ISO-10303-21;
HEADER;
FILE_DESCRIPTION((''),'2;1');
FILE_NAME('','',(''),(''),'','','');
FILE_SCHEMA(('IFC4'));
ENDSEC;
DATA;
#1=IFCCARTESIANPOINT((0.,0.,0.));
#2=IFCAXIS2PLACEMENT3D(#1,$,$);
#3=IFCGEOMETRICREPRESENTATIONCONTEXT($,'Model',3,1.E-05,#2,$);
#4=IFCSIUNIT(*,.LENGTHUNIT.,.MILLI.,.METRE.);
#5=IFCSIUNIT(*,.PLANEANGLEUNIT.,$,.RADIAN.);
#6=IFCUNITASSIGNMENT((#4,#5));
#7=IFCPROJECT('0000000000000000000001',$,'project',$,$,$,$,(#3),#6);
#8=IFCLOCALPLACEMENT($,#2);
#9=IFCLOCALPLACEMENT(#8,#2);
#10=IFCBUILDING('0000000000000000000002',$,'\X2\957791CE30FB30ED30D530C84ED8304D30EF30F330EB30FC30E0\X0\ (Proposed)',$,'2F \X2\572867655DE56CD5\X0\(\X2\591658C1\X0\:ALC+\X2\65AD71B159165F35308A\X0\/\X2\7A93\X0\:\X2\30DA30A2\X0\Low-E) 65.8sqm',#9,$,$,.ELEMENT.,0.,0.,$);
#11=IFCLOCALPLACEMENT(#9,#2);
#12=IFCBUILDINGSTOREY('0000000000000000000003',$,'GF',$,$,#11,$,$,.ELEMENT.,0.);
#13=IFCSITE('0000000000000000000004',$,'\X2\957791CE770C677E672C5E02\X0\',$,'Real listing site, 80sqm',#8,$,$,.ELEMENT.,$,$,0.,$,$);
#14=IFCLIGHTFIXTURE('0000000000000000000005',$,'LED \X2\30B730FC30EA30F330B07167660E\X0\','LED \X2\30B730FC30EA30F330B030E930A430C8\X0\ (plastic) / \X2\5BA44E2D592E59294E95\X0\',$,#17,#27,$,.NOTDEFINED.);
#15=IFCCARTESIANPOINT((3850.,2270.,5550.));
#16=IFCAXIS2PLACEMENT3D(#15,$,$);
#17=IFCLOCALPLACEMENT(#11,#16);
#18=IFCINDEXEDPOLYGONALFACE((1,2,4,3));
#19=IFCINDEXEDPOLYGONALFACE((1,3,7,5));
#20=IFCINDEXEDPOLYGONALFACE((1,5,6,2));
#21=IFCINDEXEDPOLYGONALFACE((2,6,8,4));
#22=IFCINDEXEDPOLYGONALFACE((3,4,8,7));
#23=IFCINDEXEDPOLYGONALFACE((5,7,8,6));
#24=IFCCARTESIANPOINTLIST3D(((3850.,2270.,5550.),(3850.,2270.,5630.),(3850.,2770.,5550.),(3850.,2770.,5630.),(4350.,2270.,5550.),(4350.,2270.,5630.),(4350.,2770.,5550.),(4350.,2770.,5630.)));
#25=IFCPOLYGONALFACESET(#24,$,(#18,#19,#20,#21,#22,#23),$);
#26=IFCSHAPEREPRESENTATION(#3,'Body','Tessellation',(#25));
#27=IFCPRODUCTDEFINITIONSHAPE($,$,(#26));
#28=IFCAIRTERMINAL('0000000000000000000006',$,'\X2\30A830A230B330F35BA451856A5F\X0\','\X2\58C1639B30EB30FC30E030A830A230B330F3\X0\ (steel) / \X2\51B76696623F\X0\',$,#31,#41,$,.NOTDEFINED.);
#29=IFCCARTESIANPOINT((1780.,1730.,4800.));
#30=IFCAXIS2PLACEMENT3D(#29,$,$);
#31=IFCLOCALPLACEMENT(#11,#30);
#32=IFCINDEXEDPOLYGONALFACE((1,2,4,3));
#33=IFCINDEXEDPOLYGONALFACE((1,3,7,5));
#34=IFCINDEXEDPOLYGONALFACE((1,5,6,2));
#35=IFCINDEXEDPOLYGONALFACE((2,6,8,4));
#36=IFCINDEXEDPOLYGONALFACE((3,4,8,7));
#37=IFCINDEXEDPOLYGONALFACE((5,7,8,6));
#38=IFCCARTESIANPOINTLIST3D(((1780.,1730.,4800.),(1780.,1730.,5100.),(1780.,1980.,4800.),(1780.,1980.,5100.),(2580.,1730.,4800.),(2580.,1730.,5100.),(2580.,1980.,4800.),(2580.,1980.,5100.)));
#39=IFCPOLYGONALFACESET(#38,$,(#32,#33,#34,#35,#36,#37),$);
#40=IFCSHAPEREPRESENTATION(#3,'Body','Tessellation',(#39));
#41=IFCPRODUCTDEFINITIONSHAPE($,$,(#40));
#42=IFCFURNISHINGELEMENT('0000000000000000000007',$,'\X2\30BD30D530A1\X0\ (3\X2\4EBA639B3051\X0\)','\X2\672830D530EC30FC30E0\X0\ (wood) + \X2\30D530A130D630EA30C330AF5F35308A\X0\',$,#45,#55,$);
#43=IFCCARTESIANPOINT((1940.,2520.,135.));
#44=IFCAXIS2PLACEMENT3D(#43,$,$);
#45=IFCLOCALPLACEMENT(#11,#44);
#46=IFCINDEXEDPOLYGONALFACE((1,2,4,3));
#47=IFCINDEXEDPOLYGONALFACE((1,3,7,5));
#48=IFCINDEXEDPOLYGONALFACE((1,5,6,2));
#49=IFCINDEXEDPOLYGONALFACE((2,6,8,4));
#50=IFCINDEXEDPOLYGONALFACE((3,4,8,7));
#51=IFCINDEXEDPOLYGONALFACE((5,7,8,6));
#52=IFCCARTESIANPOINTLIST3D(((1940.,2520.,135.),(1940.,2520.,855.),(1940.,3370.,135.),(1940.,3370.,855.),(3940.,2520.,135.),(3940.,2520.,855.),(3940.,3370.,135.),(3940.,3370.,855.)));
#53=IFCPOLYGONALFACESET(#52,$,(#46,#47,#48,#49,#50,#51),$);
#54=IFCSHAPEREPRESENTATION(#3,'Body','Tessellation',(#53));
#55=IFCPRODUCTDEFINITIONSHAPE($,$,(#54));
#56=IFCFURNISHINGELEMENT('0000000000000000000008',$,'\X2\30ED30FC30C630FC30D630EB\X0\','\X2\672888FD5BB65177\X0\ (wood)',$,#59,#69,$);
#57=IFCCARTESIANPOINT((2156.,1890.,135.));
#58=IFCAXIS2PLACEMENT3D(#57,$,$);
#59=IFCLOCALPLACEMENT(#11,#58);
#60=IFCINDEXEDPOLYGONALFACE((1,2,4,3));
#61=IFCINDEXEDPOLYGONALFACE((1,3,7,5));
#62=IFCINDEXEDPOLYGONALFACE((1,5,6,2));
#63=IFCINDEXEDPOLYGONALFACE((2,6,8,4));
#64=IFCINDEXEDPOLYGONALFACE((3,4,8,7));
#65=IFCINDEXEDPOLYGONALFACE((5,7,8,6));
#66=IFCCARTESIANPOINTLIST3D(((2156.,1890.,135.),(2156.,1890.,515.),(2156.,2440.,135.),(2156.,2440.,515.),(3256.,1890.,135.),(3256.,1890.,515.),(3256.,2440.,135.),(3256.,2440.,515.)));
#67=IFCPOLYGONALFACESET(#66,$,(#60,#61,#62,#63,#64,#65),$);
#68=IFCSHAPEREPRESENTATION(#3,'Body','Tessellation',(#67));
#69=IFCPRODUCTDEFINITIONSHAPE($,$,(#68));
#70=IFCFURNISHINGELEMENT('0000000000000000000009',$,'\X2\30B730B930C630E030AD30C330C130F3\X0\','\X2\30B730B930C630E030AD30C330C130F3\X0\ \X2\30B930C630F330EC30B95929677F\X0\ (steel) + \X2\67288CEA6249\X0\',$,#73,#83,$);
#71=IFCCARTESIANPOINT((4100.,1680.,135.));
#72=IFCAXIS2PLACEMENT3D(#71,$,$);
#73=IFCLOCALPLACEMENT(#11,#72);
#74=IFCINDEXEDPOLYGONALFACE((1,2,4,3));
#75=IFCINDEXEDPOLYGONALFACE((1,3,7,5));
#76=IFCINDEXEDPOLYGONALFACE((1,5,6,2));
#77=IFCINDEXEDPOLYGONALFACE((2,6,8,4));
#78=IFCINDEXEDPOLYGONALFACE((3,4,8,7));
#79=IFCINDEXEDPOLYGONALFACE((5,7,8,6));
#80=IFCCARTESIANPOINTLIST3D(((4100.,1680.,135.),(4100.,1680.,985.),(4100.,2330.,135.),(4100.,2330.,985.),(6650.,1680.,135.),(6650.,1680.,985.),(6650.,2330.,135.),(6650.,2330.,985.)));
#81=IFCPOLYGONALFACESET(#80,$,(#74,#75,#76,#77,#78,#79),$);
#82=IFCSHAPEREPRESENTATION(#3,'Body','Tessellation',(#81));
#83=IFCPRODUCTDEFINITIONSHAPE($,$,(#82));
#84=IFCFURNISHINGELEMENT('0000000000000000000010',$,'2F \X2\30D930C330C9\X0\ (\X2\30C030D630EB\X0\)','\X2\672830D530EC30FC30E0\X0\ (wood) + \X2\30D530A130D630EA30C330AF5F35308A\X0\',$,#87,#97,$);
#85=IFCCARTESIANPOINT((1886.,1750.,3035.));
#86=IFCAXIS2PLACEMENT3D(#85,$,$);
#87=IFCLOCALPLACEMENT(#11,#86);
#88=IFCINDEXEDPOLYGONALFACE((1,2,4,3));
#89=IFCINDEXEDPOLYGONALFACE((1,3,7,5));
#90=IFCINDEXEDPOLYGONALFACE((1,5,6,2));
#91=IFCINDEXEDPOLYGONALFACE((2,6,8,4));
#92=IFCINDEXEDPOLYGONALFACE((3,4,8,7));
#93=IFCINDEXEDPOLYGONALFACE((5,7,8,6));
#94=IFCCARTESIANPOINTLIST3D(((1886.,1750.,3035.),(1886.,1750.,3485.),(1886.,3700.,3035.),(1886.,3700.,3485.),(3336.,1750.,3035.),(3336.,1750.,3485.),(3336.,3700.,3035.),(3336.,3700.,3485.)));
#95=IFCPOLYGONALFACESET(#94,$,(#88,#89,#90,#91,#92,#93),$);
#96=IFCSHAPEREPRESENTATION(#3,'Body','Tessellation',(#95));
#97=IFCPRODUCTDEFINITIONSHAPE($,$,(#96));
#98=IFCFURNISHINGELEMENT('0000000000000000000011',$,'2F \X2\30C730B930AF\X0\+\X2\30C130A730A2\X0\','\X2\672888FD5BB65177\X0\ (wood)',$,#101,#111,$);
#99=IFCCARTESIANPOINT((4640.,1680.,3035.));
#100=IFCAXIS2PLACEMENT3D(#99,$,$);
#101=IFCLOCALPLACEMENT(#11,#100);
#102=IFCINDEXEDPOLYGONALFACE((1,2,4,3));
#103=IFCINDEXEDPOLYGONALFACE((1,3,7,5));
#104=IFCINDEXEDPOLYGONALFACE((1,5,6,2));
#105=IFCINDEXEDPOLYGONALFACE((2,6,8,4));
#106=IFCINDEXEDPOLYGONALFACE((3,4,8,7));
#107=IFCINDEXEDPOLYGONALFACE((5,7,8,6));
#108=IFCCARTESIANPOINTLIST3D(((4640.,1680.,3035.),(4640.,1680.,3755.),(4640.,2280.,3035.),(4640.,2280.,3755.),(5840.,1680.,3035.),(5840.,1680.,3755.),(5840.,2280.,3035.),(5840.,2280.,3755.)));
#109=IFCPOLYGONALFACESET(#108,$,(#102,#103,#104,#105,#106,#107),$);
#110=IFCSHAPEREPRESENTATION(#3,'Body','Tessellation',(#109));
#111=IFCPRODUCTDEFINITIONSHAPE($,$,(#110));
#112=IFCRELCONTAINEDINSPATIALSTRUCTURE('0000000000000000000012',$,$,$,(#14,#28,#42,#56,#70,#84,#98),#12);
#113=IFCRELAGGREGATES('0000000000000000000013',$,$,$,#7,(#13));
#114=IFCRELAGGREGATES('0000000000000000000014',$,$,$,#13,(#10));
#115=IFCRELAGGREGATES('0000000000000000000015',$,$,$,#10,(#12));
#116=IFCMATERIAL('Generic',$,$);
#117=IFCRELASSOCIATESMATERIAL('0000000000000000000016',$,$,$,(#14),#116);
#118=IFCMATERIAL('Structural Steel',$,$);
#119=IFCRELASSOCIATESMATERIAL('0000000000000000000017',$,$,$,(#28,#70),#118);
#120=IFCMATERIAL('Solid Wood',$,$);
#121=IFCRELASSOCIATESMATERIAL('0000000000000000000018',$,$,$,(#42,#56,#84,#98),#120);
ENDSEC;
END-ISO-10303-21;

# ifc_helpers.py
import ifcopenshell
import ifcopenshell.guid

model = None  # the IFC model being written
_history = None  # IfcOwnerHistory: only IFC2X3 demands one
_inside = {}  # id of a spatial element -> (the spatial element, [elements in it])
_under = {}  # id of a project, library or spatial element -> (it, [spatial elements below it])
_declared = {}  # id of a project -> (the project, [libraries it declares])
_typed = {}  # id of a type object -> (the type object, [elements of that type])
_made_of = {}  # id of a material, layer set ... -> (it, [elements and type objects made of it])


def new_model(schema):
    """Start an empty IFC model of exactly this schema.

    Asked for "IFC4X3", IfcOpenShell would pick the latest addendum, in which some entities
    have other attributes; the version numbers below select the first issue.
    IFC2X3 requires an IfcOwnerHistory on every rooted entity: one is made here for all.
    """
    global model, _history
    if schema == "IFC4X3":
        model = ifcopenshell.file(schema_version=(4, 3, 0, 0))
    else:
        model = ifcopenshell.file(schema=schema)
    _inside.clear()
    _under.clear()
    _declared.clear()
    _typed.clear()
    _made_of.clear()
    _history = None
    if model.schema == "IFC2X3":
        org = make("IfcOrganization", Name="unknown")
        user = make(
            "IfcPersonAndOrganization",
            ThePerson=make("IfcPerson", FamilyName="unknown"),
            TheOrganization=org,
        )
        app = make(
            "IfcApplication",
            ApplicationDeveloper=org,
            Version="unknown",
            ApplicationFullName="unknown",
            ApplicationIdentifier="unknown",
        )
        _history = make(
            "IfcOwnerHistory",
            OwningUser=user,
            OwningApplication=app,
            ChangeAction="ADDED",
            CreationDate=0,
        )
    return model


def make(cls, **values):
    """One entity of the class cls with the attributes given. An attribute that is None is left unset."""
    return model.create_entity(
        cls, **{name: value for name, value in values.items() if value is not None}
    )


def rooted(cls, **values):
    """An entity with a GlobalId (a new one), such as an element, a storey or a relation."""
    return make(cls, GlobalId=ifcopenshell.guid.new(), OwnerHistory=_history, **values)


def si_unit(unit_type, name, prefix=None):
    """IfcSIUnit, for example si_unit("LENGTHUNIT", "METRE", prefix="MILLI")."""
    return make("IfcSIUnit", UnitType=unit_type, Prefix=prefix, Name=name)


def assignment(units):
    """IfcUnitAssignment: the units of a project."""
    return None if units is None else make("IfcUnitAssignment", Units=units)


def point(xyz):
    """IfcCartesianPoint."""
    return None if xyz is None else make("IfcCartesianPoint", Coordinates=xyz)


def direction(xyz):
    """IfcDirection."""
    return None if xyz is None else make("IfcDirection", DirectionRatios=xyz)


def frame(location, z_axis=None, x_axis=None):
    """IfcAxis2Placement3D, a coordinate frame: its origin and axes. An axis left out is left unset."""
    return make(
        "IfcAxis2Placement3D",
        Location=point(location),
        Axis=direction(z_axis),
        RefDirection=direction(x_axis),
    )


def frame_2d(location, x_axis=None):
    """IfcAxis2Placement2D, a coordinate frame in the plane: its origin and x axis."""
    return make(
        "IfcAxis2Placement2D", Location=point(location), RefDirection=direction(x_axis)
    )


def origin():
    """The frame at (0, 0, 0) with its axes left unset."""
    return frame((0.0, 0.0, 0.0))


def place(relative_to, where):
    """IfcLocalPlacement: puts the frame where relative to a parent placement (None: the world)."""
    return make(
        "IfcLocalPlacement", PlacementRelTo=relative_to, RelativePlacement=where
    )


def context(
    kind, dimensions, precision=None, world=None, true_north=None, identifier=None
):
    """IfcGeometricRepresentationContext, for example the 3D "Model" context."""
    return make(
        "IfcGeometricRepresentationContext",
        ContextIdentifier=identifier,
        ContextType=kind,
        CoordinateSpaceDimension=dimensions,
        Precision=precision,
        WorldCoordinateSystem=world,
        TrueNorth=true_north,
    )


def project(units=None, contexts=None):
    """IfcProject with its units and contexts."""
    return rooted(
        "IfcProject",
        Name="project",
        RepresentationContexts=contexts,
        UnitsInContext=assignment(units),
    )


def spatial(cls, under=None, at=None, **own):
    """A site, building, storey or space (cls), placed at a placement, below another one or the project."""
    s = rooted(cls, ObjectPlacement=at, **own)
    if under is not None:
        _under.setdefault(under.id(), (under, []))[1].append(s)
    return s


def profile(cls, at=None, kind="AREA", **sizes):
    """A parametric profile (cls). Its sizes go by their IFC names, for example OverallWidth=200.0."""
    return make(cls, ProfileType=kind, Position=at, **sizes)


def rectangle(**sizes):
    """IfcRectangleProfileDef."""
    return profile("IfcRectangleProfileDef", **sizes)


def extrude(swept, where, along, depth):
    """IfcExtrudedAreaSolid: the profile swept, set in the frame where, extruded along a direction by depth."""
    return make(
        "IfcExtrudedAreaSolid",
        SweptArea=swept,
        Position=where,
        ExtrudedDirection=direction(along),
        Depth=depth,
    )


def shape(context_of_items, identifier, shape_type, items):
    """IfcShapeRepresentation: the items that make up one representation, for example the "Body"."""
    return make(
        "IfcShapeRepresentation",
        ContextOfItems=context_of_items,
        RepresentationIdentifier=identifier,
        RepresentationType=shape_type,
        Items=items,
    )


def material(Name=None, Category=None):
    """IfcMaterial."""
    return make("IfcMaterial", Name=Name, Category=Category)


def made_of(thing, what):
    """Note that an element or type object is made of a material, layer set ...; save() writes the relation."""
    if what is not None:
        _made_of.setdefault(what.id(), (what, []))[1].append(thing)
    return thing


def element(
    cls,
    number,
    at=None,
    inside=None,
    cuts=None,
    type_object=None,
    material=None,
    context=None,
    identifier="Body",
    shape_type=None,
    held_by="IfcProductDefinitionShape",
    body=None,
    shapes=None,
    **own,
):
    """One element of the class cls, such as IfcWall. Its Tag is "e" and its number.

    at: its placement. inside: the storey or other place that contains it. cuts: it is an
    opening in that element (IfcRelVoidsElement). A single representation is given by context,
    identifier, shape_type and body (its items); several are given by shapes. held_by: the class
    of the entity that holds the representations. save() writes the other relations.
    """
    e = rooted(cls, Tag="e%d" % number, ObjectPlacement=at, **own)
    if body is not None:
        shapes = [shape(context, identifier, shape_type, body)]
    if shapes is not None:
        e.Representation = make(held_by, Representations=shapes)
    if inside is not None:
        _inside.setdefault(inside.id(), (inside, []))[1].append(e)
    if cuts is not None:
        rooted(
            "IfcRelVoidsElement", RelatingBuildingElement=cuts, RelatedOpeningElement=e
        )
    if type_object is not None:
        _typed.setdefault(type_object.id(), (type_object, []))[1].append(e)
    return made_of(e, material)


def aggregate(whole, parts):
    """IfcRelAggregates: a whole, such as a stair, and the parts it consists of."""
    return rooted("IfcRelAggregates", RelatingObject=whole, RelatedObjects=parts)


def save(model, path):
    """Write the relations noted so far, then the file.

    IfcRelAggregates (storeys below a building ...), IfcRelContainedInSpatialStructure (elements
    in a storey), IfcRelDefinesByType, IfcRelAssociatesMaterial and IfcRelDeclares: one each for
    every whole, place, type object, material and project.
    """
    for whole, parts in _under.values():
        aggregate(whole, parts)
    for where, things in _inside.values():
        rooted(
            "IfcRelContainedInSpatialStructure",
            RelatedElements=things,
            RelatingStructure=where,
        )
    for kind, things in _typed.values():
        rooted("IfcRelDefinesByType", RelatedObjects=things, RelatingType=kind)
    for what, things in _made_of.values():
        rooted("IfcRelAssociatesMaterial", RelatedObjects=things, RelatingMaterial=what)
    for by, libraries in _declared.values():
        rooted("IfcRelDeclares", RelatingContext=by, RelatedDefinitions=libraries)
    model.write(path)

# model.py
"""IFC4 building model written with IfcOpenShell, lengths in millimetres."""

from ifc_helpers import new_model, si_unit, frame, frame_2d, origin, place, context, project, spatial, rectangle, extrude, material, element, save


model = new_model("IFC4")

# Units and contexts
model_context = context("Model", 3, precision=1e-05, world=origin())
ifc_project = project(units=[si_unit("LENGTHUNIT", "METRE", prefix="MILLI"), si_unit("PLANEANGLEUNIT", "RADIAN")], contexts=[model_context])

# Site, building, storey
site_placement = place(None, origin())
site = spatial("IfcSite", under=ifc_project, at=site_placement, Name="長野県松本市", ObjectType="Real listing site, 80sqm", CompositionType="ELEMENT", RefElevation=0.0)
building_placement = place(site_placement, origin())
building = spatial("IfcBuilding", under=site, at=building_placement, Name="長野・ロフト付きワンルーム (Proposed)", ObjectType="2F 在来工法(外壁:ALC+断熱外張り/窓:ペアLow-E) 65.8sqm", CompositionType="ELEMENT", ElevationOfRefHeight=0.0, ElevationOfTerrain=0.0)
storey_placement = place(building_placement, origin())
storey = spatial("IfcBuildingStorey", under=building, at=storey_placement, Name="GF", CompositionType="ELEMENT", Elevation=0.0)

# Shared definitions
ifc_material_1 = material(Name="Solid Wood")

# Shared definitions
ifc_material_2 = material(Name="Generic")

# Shared definitions
ifc_material_3 = material(Name="Structural Steel")

# Light fixture
light_fixture_1_placement = place(storey_placement, frame((3850.0, 2270.0, 5550.0)))
element("IfcLightFixture", 1, at=light_fixture_1_placement, inside=storey, material=ifc_material_2, Name="LED シーリング照明", Description="LED シーリングライト (plastic) / 室中央天井", PredefinedType="NOTDEFINED", context=model_context, shape_type="SweptSolid", body=[
    extrude(rectangle(XDim=500.0, YDim=500.0, at=frame_2d((250.0, 250.0))), frame((3850.0, 2270.0, 5550.0)), (0.0, 0.0, 1.0), 80.0),
])

# Air terminal
air_terminal_placement = place(storey_placement, frame((1780.0, 1730.0, 4800.0)))
element("IfcAirTerminal", 2, at=air_terminal_placement, inside=storey, material=ifc_material_3, Name="エアコン室内機", Description="壁掛ルームエアコン (steel) / 冷暖房", PredefinedType="NOTDEFINED", context=model_context, shape_type="SweptSolid", body=[
    extrude(rectangle(XDim=800.0, YDim=250.0, at=frame_2d((400.0, 125.0))), frame((1780.0, 1730.0, 4800.0)), (0.0, 0.0, 1.0), 300.0),
])

# Furnishing elements
furnishing_1_placement = place(storey_placement, frame((1940.0, 2520.0, 135.0)))
element("IfcFurnishingElement", 3, at=furnishing_1_placement, inside=storey, material=ifc_material_1, Name="ソファ (3人掛け)", Description="木フレーム (wood) + ファブリック張り", context=model_context, shape_type="SweptSolid", body=[
    extrude(rectangle(XDim=2000.0, YDim=850.0, at=frame_2d((1000.0, 425.0))), frame((1940.0, 2520.0, 135.0)), (0.0, 0.0, 1.0), 720.0),
])
furnishing_2_placement = place(storey_placement, frame((2156.0, 1890.0, 135.0)))
element("IfcFurnishingElement", 4, at=furnishing_2_placement, inside=storey, material=ifc_material_1, Name="ローテーブル", Description="木製家具 (wood)", context=model_context, shape_type="SweptSolid", body=[
    extrude(rectangle(XDim=1100.0, YDim=550.0, at=frame_2d((550.0, 275.0))), frame((2156.0, 1890.0, 135.0)), (0.0, 0.0, 1.0), 380.0),
])
furnishing_3_placement = place(storey_placement, frame((4100.0, 1680.0, 135.0)))
element("IfcFurnishingElement", 5, at=furnishing_3_placement, inside=storey, material=ifc_material_3, Name="システムキッチン", Description="システムキッチン ステンレス天板 (steel) + 木質扉", context=model_context, shape_type="SweptSolid", body=[
    extrude(rectangle(XDim=2550.0, YDim=650.0, at=frame_2d((1275.0, 325.0))), frame((4100.0, 1680.0, 135.0)), (0.0, 0.0, 1.0), 850.0),
])
furnishing_4_placement = place(storey_placement, frame((1886.0, 1750.0, 3035.0)))
element("IfcFurnishingElement", 6, at=furnishing_4_placement, inside=storey, material=ifc_material_1, Name="2F ベッド (ダブル)", Description="木フレーム (wood) + ファブリック張り", context=model_context, shape_type="SweptSolid", body=[
    extrude(rectangle(XDim=1450.0, YDim=1950.0, at=frame_2d((725.0, 975.0))), frame((1886.0, 1750.0, 3035.0)), (0.0, 0.0, 1.0), 450.0),
])
furnishing_5_placement = place(storey_placement, frame((4640.0, 1680.0, 3035.0)))
element("IfcFurnishingElement", 7, at=furnishing_5_placement, inside=storey, material=ifc_material_1, Name="2F デスク+チェア", Description="木製家具 (wood)", context=model_context, shape_type="SweptSolid", body=[
    extrude(rectangle(XDim=1200.0, YDim=600.0, at=frame_2d((600.0, 300.0))), frame((4640.0, 1680.0, 3035.0)), (0.0, 0.0, 1.0), 720.0),
])

save(model, "model.ifc")
